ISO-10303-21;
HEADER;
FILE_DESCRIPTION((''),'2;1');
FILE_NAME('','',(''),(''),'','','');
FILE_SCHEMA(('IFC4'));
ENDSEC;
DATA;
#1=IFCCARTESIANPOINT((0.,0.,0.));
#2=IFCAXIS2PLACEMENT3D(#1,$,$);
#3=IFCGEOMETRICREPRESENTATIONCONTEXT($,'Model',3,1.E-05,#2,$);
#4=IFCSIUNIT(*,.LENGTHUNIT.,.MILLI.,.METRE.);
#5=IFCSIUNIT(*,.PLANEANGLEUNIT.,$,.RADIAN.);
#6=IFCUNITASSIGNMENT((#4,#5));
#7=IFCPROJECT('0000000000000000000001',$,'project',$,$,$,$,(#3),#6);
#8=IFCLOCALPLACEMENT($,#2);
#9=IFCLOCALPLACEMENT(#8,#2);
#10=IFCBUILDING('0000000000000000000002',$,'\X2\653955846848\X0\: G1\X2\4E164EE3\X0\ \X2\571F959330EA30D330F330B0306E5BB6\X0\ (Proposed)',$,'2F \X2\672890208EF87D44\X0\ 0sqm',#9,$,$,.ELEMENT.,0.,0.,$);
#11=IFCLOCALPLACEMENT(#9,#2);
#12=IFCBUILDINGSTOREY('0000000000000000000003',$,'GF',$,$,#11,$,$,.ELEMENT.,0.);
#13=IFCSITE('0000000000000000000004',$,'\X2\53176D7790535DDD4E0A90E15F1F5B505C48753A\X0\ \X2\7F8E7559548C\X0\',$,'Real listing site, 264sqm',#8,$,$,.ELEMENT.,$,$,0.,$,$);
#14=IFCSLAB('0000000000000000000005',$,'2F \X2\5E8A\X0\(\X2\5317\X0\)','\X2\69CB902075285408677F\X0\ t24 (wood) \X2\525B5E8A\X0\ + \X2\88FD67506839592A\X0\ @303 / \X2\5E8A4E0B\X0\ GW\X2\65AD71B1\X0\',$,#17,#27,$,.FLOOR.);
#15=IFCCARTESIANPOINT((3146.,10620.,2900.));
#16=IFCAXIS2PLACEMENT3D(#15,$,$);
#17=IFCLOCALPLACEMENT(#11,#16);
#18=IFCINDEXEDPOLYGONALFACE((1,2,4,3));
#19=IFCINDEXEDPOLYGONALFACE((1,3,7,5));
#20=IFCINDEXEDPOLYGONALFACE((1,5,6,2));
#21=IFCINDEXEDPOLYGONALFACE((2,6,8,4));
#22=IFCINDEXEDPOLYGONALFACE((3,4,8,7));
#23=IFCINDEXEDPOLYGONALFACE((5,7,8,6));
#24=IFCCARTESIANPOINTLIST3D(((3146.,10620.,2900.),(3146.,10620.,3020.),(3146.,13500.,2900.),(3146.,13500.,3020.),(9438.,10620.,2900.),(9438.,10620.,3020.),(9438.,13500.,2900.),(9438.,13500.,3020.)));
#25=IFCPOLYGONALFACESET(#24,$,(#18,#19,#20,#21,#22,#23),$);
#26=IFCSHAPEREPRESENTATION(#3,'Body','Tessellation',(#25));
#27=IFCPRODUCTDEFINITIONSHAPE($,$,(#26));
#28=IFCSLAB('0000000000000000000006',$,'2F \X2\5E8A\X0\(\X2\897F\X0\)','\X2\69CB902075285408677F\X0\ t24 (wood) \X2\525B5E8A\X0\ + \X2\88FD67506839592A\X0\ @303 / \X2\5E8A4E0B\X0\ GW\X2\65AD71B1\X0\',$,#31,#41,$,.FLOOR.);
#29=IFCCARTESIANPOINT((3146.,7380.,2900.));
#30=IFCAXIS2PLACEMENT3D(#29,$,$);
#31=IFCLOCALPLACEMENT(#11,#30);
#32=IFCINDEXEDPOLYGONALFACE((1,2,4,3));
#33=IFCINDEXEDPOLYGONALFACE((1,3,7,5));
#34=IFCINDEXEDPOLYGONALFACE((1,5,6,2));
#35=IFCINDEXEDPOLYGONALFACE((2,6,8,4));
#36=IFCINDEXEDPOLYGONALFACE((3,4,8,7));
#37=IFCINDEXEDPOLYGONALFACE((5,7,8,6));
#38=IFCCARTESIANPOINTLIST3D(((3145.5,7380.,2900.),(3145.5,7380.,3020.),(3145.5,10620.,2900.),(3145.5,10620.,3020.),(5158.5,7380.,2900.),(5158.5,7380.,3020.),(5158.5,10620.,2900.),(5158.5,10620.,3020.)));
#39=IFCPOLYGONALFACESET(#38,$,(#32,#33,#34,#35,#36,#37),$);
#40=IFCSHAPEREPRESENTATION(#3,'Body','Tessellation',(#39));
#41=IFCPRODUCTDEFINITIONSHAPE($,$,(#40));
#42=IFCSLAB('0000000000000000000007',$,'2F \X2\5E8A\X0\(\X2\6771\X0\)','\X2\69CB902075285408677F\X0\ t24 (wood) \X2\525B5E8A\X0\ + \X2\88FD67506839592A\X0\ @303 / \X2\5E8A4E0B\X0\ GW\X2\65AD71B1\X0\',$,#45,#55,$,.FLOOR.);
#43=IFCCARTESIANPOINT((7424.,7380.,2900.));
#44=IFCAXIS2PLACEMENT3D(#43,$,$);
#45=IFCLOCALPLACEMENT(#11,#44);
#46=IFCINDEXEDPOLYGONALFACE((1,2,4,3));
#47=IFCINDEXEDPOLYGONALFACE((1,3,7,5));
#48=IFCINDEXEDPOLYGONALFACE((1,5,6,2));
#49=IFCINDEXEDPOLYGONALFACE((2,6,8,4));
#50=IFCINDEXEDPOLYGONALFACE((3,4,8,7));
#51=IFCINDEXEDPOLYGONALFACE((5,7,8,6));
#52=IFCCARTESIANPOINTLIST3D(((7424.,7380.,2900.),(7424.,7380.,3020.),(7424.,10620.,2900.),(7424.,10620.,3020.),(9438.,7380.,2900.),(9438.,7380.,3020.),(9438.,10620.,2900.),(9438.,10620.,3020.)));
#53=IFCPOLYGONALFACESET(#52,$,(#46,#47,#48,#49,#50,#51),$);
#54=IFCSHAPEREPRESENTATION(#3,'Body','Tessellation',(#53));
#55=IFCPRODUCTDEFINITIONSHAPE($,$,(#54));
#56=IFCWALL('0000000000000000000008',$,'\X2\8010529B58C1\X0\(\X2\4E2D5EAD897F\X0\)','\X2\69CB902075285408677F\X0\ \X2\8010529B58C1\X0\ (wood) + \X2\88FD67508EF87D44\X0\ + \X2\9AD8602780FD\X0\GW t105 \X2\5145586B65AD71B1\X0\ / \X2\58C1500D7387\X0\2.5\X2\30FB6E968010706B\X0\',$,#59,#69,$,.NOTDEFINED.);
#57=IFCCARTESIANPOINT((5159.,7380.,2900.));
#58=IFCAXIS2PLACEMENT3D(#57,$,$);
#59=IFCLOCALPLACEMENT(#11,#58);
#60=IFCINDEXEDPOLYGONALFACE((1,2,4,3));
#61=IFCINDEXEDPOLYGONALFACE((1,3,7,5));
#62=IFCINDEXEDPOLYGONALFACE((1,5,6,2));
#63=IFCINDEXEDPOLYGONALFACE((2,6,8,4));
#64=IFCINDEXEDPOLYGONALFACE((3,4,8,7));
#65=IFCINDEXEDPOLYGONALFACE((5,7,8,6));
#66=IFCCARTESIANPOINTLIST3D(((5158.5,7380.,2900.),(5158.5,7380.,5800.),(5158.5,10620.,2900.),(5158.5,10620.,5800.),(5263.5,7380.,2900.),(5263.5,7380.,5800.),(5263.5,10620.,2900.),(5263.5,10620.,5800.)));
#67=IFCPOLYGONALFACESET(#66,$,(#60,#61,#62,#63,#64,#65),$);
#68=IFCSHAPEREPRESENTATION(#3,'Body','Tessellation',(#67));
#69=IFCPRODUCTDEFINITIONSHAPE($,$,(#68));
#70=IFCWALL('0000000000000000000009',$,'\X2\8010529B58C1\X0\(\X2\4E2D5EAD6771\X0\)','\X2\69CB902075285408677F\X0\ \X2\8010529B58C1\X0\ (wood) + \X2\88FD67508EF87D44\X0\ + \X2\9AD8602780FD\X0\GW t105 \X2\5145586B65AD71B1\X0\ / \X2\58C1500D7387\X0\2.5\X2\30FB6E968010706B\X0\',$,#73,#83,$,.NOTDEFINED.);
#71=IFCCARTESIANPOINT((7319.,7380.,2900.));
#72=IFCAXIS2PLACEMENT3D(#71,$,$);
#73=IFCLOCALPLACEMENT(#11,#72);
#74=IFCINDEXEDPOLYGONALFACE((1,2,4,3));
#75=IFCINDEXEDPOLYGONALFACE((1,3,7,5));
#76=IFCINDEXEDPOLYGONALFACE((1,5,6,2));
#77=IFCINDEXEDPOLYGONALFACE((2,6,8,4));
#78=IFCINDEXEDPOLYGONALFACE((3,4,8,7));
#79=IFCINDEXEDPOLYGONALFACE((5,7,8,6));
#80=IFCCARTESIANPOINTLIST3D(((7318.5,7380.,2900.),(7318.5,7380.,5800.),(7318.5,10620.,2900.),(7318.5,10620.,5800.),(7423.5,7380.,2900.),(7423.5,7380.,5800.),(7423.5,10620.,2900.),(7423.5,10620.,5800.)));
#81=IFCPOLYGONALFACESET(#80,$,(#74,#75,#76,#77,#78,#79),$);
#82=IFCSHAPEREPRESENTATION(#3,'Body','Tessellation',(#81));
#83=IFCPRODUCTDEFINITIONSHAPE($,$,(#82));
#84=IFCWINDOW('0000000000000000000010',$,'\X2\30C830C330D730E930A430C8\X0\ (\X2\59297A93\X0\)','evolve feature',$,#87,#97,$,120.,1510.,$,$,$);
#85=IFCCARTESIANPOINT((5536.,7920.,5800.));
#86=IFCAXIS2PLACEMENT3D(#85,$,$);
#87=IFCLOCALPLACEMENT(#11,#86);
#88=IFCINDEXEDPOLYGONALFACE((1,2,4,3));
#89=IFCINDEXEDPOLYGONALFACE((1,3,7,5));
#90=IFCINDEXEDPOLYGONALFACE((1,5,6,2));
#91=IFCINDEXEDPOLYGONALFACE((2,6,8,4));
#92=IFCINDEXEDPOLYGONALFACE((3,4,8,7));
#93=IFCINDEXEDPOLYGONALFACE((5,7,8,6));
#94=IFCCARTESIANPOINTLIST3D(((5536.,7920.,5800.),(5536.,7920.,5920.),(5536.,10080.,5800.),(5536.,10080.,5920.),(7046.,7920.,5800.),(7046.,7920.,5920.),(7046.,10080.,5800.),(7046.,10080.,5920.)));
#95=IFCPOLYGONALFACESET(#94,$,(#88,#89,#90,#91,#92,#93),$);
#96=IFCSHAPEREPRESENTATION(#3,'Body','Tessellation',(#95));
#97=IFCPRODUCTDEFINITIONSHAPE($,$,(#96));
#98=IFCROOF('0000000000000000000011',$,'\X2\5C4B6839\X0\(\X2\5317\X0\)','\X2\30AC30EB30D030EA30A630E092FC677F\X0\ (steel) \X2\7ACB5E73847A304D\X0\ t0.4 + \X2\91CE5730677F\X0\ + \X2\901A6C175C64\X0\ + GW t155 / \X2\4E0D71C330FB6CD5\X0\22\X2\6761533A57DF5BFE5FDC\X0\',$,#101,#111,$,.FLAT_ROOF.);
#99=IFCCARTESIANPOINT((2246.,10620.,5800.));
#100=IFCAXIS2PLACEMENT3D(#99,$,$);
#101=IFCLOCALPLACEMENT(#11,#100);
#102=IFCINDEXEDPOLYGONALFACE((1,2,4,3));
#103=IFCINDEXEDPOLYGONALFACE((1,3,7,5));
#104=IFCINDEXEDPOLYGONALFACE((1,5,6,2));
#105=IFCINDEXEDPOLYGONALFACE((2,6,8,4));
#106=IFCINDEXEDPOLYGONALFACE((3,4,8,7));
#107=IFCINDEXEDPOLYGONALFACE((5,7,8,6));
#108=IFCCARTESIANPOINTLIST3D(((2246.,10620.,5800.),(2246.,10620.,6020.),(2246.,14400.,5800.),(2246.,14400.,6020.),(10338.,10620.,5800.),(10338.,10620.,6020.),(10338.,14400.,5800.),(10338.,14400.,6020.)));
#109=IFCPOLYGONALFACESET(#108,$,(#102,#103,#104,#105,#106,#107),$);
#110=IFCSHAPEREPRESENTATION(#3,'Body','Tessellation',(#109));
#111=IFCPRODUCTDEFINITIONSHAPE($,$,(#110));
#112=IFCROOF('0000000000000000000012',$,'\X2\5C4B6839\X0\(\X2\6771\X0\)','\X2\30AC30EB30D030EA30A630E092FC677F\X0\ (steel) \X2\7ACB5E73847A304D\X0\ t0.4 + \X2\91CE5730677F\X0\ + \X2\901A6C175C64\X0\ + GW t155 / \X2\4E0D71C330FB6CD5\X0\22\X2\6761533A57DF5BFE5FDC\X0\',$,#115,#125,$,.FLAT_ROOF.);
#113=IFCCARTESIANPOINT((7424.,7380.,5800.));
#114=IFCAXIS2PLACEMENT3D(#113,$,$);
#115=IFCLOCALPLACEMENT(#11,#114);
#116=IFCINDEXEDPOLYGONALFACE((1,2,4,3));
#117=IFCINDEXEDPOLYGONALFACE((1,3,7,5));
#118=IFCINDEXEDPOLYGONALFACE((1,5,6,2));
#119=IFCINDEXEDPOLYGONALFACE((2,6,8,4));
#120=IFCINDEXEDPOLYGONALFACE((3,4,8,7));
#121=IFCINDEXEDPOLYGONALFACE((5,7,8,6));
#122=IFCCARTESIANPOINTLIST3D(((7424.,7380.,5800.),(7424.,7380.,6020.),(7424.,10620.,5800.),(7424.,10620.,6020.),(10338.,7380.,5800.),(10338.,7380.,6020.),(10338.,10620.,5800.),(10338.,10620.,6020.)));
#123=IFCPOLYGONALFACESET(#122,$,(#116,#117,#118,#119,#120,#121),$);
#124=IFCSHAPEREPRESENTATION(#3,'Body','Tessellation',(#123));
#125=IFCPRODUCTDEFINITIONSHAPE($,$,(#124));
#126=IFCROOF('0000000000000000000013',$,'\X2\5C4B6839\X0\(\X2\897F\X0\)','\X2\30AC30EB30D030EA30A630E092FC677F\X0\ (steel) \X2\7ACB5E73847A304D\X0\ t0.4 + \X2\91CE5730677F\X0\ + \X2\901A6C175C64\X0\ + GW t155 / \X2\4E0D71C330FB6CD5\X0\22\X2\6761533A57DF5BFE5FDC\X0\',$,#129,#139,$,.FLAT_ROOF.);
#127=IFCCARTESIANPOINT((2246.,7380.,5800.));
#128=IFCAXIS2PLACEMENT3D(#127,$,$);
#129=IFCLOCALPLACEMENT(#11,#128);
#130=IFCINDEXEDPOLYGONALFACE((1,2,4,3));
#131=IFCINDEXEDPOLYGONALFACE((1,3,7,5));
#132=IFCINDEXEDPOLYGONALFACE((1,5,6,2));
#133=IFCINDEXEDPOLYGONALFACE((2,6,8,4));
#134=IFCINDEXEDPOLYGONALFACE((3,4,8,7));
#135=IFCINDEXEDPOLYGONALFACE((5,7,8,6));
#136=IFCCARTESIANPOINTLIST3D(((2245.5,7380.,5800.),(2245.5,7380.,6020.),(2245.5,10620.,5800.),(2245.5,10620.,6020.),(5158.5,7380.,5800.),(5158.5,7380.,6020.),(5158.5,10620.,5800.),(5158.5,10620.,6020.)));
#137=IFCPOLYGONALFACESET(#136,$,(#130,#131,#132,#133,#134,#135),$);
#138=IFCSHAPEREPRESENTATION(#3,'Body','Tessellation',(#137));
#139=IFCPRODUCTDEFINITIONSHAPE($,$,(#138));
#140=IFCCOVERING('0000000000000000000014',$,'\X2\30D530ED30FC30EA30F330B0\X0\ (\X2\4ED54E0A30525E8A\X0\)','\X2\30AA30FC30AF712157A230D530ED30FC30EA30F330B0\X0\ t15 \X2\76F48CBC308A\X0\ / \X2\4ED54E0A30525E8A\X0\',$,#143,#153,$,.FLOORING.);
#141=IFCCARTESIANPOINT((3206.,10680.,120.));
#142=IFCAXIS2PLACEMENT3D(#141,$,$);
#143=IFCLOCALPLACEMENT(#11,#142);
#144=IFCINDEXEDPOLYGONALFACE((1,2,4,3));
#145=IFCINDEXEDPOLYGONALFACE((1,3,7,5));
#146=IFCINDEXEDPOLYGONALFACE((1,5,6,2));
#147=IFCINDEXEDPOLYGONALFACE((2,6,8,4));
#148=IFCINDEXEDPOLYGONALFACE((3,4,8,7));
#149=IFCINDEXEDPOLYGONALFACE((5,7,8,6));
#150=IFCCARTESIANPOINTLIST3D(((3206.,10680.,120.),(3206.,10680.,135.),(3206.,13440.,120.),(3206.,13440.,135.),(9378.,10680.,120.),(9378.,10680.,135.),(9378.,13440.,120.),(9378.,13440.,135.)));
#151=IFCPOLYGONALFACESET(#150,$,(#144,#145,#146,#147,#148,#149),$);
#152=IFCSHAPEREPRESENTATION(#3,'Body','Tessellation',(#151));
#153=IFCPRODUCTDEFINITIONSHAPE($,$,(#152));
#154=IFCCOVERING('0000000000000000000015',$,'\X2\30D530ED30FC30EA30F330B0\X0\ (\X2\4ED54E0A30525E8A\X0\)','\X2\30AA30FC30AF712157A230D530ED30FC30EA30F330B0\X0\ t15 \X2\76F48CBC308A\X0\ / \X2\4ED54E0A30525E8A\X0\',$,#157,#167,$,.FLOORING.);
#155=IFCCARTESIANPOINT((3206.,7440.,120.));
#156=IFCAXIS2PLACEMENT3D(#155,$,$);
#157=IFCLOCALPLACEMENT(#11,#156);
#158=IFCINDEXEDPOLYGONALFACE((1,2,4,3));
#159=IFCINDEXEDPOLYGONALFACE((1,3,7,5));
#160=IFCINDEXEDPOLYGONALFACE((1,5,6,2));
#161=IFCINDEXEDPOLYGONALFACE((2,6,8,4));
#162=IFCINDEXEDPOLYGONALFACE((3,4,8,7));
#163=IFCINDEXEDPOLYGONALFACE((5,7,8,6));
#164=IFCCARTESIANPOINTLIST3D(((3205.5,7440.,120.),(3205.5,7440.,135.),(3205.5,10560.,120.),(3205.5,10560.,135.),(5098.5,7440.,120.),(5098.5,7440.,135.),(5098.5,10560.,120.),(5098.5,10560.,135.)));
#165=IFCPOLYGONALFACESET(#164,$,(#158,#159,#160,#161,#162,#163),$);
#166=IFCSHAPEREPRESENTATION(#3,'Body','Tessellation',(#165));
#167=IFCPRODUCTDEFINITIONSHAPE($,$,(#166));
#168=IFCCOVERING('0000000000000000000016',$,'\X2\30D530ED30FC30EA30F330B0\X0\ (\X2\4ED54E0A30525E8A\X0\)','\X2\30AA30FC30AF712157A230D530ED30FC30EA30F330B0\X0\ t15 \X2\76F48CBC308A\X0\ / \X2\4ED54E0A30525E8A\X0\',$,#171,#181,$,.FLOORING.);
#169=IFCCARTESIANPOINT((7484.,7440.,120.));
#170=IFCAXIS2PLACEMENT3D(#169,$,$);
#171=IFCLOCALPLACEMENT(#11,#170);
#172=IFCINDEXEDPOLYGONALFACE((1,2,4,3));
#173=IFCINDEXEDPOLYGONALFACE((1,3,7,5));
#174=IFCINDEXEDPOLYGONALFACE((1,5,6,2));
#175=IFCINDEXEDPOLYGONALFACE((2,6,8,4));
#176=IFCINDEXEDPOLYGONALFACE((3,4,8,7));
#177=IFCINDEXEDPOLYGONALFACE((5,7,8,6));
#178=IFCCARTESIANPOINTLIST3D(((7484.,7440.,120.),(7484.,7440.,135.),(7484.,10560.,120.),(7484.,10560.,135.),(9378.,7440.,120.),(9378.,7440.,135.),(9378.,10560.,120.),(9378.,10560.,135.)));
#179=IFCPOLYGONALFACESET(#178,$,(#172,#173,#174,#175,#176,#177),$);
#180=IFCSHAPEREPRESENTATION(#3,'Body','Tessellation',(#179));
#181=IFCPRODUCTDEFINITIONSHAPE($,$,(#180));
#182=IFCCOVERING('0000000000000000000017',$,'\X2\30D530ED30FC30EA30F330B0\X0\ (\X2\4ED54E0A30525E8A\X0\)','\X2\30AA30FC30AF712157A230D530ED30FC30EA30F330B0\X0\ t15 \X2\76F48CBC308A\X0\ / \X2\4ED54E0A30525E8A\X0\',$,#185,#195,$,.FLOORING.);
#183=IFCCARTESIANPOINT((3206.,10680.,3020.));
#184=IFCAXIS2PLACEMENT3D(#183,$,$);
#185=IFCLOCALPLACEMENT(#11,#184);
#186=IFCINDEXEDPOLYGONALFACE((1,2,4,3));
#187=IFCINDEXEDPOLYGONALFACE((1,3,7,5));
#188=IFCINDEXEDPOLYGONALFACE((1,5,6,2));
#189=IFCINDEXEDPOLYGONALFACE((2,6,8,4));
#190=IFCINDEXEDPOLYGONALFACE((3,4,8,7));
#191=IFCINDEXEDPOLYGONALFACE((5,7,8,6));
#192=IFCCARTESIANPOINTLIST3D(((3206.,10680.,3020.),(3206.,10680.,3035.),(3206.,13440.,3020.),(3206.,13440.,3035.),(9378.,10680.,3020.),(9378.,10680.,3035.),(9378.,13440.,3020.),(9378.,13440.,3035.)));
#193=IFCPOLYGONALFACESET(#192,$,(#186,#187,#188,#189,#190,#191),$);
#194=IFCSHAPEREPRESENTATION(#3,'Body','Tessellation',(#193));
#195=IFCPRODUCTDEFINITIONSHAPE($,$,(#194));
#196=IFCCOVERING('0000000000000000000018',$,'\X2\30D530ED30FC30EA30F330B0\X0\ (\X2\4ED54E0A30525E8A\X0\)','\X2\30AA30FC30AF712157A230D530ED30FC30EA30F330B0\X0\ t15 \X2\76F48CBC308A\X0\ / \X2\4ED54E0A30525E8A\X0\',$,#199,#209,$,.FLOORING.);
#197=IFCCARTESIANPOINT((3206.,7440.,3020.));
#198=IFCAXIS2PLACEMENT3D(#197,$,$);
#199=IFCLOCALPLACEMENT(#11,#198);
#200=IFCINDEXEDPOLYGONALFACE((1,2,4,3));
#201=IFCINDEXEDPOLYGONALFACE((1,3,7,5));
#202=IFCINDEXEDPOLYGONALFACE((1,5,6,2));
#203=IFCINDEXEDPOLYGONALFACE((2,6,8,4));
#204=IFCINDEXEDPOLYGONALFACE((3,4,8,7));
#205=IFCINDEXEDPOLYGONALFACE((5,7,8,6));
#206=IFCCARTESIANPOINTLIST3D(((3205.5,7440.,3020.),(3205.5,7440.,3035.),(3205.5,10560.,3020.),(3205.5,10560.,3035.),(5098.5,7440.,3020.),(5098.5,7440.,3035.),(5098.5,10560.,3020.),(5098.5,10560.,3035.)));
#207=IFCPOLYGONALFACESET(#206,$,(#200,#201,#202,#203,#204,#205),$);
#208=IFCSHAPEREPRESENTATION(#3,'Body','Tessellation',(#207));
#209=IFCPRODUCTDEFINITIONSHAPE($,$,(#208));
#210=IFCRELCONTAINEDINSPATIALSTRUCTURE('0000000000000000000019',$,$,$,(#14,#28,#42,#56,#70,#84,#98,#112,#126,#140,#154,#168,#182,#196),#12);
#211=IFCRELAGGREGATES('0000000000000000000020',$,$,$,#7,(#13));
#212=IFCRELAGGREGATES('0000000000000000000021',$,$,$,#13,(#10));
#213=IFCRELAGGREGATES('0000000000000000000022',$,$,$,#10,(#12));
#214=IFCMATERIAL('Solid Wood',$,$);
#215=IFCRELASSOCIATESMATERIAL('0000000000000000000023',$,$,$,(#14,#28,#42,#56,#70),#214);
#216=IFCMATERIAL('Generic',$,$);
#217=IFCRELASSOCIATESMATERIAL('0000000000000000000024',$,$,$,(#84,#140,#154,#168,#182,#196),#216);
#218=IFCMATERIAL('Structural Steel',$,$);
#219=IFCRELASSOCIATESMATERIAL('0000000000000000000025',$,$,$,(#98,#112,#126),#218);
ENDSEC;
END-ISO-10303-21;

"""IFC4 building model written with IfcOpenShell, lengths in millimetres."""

from ifc_helpers import new_model, si_unit, frame, frame_2d, origin, place, context, project, spatial, rectangle, extrude, material, element, save


model = new_model("IFC4")

# Units and contexts
model_context = context("Model", 3, precision=1e-05, world=origin())
ifc_project = project(units=[si_unit("LENGTHUNIT", "METRE", prefix="MILLI"), si_unit("PLANEANGLEUNIT", "RADIAN")], contexts=[model_context])

# Site, building, storey
site_placement = place(None, origin())
site = spatial("IfcSite", under=ifc_project, at=site_placement, Name="北海道川上郡弟子屈町 美留和", ObjectType="Real listing site, 264sqm", CompositionType="ELEMENT", RefElevation=0.0)
building_placement = place(site_placement, origin())
building = spatial("IfcBuilding", under=site, at=building_placement, Name="改善案: G1世代 土間リビングの家 (Proposed)", ObjectType="2F 木造軸組 0sqm", CompositionType="ELEMENT", ElevationOfRefHeight=0.0, ElevationOfTerrain=0.0)
storey_placement = place(building_placement, origin())
storey = spatial("IfcBuildingStorey", under=building, at=storey_placement, Name="GF", CompositionType="ELEMENT", Elevation=0.0)

# Slabs
ifc_material_1 = material(Name="Solid Wood")
slab_1_placement = place(storey_placement, frame((3146.0, 10620.0, 2900.0)))
element("IfcSlab", 1, at=slab_1_placement, inside=storey, material=ifc_material_1, Name="2F 床(北)", Description="構造用合板 t24 (wood) 剛床 + 製材根太 @303 / 床下 GW断熱", PredefinedType="FLOOR", context=model_context, shape_type="SweptSolid", body=[
    extrude(rectangle(XDim=6292.0, YDim=2880.0, at=frame_2d((3146.0, 1440.0))), frame((3146.0, 10620.0, 2900.0)), (0.0, 0.0, 1.0), 120.0),
])
slab_2_placement = place(storey_placement, frame((3146.0, 7380.0, 2900.0)))
element("IfcSlab", 2, at=slab_2_placement, inside=storey, material=ifc_material_1, Name="2F 床(西)", Description="構造用合板 t24 (wood) 剛床 + 製材根太 @303 / 床下 GW断熱", PredefinedType="FLOOR", context=model_context, shape_type="SweptSolid", body=[
    extrude(rectangle(XDim=2013.0, YDim=3240.0, at=frame_2d((1006.0, 1620.0))), frame((3146.0, 7380.0, 2900.0)), (0.0, 0.0, 1.0), 120.0),
])
slab_3_placement = place(storey_placement, frame((7424.0, 7380.0, 2900.0)))
element("IfcSlab", 3, at=slab_3_placement, inside=storey, material=ifc_material_1, Name="2F 床(東)", Description="構造用合板 t24 (wood) 剛床 + 製材根太 @303 / 床下 GW断熱", PredefinedType="FLOOR", context=model_context, shape_type="SweptSolid", body=[
    extrude(rectangle(XDim=2014.0, YDim=3240.0, at=frame_2d((1007.0, 1620.0))), frame((7424.0, 7380.0, 2900.0)), (0.0, 0.0, 1.0), 120.0),
])

# Walls
wall_1_placement = place(storey_placement, frame((5159.0, 7380.0, 2900.0)))
element("IfcWall", 4, at=wall_1_placement, inside=storey, material=ifc_material_1, Name="耐力壁(中庭西)", Description="構造用合板 耐力壁 (wood) + 製材軸組 + 高性能GW t105 充填断熱 / 壁倍率2.5・準耐火", PredefinedType="NOTDEFINED", context=model_context, shape_type="SweptSolid", body=[
    extrude(rectangle(XDim=105.0, YDim=3240.0, at=frame_2d((52.0, 1620.0))), frame((5159.0, 7380.0, 2900.0)), (0.0, 0.0, 1.0), 2900.0),
])
wall_2_placement = place(storey_placement, frame((7319.0, 7380.0, 2900.0)))
element("IfcWall", 5, at=wall_2_placement, inside=storey, material=ifc_material_1, Name="耐力壁(中庭東)", Description="構造用合板 耐力壁 (wood) + 製材軸組 + 高性能GW t105 充填断熱 / 壁倍率2.5・準耐火", PredefinedType="NOTDEFINED", context=model_context, shape_type="SweptSolid", body=[
    extrude(rectangle(XDim=105.0, YDim=3240.0, at=frame_2d((52.0, 1620.0))), frame((7319.0, 7380.0, 2900.0)), (0.0, 0.0, 1.0), 2900.0),
])

# Window
ifc_material_2 = material(Name="Generic")
window_1_placement = place(storey_placement, frame((5536.0, 7920.0, 5800.0)))
element("IfcWindow", 6, at=window_1_placement, inside=storey, material=ifc_material_2, Name="トップライト (天窓)", Description="evolve feature", OverallHeight=120.0, OverallWidth=1510.0, context=model_context, shape_type="SweptSolid", body=[
    extrude(rectangle(XDim=1510.0, YDim=2160.0, at=frame_2d((755.0, 1080.0))), frame((5536.0, 7920.0, 5800.0)), (0.0, 0.0, 1.0), 120.0),
])

# Roofs
ifc_material_3 = material(Name="Structural Steel")
roof_1_placement = place(storey_placement, frame((2246.0, 10620.0, 5800.0)))
element("IfcRoof", 7, at=roof_1_placement, inside=storey, material=ifc_material_3, Name="屋根(北)", Description="ガルバリウム鋼板 (steel) 立平葺き t0.4 + 野地板 + 通気層 + GW t155 / 不燃・法22条区域対応", PredefinedType="FLAT_ROOF", context=model_context, shape_type="SweptSolid", body=[
    extrude(rectangle(XDim=8092.0, YDim=3780.0, at=frame_2d((4046.0, 1890.0))), frame((2246.0, 10620.0, 5800.0)), (0.0, 0.0, 1.0), 220.0),
])
roof_2_placement = place(storey_placement, frame((7424.0, 7380.0, 5800.0)))
element("IfcRoof", 8, at=roof_2_placement, inside=storey, material=ifc_material_3, Name="屋根(東)", Description="ガルバリウム鋼板 (steel) 立平葺き t0.4 + 野地板 + 通気層 + GW t155 / 不燃・法22条区域対応", PredefinedType="FLAT_ROOF", context=model_context, shape_type="SweptSolid", body=[
    extrude(rectangle(XDim=2914.0, YDim=3240.0, at=frame_2d((1457.0, 1620.0))), frame((7424.0, 7380.0, 5800.0)), (0.0, 0.0, 1.0), 220.0),
])
roof_3_placement = place(storey_placement, frame((2246.0, 7380.0, 5800.0)))
element("IfcRoof", 9, at=roof_3_placement, inside=storey, material=ifc_material_3, Name="屋根(西)", Description="ガルバリウム鋼板 (steel) 立平葺き t0.4 + 野地板 + 通気層 + GW t155 / 不燃・法22条区域対応", PredefinedType="FLAT_ROOF", context=model_context, shape_type="SweptSolid", body=[
    extrude(rectangle(XDim=2913.0, YDim=3240.0, at=frame_2d((1456.0, 1620.0))), frame((2246.0, 7380.0, 5800.0)), (0.0, 0.0, 1.0), 220.0),
])

# Coverings
covering_1_placement = place(storey_placement, frame((3206.0, 10680.0, 120.0)))
element("IfcCovering", 10, at=covering_1_placement, inside=storey, material=ifc_material_2, Name="フローリング (仕上げ床)", Description="オーク無垢フローリング t15 直貼り / 仕上げ床", PredefinedType="FLOORING", context=model_context, shape_type="SweptSolid", body=[
    extrude(rectangle(XDim=6172.0, YDim=2760.0, at=frame_2d((3086.0, 1380.0))), frame((3206.0, 10680.0, 120.0)), (0.0, 0.0, 1.0), 15.0),
])
covering_2_placement = place(storey_placement, frame((3206.0, 7440.0, 120.0)))
element("IfcCovering", 11, at=covering_2_placement, inside=storey, material=ifc_material_2, Name="フローリング (仕上げ床)", Description="オーク無垢フローリング t15 直貼り / 仕上げ床", PredefinedType="FLOORING", context=model_context, shape_type="SweptSolid", body=[
    extrude(rectangle(XDim=1893.0, YDim=3120.0, at=frame_2d((946.0, 1560.0))), frame((3206.0, 7440.0, 120.0)), (0.0, 0.0, 1.0), 15.0),
])
covering_3_placement = place(storey_placement, frame((7484.0, 7440.0, 120.0)))
element("IfcCovering", 12, at=covering_3_placement, inside=storey, material=ifc_material_2, Name="フローリング (仕上げ床)", Description="オーク無垢フローリング t15 直貼り / 仕上げ床", PredefinedType="FLOORING", context=model_context, shape_type="SweptSolid", body=[
    extrude(rectangle(XDim=1894.0, YDim=3120.0, at=frame_2d((947.0, 1560.0))), frame((7484.0, 7440.0, 120.0)), (0.0, 0.0, 1.0), 15.0),
])
covering_4_placement = place(storey_placement, frame((3206.0, 10680.0, 3020.0)))
element("IfcCovering", 13, at=covering_4_placement, inside=storey, material=ifc_material_2, Name="フローリング (仕上げ床)", Description="オーク無垢フローリング t15 直貼り / 仕上げ床", PredefinedType="FLOORING", context=model_context, shape_type="SweptSolid", body=[
    extrude(rectangle(XDim=6172.0, YDim=2760.0, at=frame_2d((3086.0, 1380.0))), frame((3206.0, 10680.0, 3020.0)), (0.0, 0.0, 1.0), 15.0),
])
covering_5_placement = place(storey_placement, frame((3206.0, 7440.0, 3020.0)))
element("IfcCovering", 14, at=covering_5_placement, inside=storey, material=ifc_material_2, Name="フローリング (仕上げ床)", Description="オーク無垢フローリング t15 直貼り / 仕上げ床", PredefinedType="FLOORING", context=model_context, shape_type="SweptSolid", body=[
    extrude(rectangle(XDim=1893.0, YDim=3120.0, at=frame_2d((946.0, 1560.0))), frame((3206.0, 7440.0, 3020.0)), (0.0, 0.0, 1.0), 15.0),
])

save(model, "model.ifc")
